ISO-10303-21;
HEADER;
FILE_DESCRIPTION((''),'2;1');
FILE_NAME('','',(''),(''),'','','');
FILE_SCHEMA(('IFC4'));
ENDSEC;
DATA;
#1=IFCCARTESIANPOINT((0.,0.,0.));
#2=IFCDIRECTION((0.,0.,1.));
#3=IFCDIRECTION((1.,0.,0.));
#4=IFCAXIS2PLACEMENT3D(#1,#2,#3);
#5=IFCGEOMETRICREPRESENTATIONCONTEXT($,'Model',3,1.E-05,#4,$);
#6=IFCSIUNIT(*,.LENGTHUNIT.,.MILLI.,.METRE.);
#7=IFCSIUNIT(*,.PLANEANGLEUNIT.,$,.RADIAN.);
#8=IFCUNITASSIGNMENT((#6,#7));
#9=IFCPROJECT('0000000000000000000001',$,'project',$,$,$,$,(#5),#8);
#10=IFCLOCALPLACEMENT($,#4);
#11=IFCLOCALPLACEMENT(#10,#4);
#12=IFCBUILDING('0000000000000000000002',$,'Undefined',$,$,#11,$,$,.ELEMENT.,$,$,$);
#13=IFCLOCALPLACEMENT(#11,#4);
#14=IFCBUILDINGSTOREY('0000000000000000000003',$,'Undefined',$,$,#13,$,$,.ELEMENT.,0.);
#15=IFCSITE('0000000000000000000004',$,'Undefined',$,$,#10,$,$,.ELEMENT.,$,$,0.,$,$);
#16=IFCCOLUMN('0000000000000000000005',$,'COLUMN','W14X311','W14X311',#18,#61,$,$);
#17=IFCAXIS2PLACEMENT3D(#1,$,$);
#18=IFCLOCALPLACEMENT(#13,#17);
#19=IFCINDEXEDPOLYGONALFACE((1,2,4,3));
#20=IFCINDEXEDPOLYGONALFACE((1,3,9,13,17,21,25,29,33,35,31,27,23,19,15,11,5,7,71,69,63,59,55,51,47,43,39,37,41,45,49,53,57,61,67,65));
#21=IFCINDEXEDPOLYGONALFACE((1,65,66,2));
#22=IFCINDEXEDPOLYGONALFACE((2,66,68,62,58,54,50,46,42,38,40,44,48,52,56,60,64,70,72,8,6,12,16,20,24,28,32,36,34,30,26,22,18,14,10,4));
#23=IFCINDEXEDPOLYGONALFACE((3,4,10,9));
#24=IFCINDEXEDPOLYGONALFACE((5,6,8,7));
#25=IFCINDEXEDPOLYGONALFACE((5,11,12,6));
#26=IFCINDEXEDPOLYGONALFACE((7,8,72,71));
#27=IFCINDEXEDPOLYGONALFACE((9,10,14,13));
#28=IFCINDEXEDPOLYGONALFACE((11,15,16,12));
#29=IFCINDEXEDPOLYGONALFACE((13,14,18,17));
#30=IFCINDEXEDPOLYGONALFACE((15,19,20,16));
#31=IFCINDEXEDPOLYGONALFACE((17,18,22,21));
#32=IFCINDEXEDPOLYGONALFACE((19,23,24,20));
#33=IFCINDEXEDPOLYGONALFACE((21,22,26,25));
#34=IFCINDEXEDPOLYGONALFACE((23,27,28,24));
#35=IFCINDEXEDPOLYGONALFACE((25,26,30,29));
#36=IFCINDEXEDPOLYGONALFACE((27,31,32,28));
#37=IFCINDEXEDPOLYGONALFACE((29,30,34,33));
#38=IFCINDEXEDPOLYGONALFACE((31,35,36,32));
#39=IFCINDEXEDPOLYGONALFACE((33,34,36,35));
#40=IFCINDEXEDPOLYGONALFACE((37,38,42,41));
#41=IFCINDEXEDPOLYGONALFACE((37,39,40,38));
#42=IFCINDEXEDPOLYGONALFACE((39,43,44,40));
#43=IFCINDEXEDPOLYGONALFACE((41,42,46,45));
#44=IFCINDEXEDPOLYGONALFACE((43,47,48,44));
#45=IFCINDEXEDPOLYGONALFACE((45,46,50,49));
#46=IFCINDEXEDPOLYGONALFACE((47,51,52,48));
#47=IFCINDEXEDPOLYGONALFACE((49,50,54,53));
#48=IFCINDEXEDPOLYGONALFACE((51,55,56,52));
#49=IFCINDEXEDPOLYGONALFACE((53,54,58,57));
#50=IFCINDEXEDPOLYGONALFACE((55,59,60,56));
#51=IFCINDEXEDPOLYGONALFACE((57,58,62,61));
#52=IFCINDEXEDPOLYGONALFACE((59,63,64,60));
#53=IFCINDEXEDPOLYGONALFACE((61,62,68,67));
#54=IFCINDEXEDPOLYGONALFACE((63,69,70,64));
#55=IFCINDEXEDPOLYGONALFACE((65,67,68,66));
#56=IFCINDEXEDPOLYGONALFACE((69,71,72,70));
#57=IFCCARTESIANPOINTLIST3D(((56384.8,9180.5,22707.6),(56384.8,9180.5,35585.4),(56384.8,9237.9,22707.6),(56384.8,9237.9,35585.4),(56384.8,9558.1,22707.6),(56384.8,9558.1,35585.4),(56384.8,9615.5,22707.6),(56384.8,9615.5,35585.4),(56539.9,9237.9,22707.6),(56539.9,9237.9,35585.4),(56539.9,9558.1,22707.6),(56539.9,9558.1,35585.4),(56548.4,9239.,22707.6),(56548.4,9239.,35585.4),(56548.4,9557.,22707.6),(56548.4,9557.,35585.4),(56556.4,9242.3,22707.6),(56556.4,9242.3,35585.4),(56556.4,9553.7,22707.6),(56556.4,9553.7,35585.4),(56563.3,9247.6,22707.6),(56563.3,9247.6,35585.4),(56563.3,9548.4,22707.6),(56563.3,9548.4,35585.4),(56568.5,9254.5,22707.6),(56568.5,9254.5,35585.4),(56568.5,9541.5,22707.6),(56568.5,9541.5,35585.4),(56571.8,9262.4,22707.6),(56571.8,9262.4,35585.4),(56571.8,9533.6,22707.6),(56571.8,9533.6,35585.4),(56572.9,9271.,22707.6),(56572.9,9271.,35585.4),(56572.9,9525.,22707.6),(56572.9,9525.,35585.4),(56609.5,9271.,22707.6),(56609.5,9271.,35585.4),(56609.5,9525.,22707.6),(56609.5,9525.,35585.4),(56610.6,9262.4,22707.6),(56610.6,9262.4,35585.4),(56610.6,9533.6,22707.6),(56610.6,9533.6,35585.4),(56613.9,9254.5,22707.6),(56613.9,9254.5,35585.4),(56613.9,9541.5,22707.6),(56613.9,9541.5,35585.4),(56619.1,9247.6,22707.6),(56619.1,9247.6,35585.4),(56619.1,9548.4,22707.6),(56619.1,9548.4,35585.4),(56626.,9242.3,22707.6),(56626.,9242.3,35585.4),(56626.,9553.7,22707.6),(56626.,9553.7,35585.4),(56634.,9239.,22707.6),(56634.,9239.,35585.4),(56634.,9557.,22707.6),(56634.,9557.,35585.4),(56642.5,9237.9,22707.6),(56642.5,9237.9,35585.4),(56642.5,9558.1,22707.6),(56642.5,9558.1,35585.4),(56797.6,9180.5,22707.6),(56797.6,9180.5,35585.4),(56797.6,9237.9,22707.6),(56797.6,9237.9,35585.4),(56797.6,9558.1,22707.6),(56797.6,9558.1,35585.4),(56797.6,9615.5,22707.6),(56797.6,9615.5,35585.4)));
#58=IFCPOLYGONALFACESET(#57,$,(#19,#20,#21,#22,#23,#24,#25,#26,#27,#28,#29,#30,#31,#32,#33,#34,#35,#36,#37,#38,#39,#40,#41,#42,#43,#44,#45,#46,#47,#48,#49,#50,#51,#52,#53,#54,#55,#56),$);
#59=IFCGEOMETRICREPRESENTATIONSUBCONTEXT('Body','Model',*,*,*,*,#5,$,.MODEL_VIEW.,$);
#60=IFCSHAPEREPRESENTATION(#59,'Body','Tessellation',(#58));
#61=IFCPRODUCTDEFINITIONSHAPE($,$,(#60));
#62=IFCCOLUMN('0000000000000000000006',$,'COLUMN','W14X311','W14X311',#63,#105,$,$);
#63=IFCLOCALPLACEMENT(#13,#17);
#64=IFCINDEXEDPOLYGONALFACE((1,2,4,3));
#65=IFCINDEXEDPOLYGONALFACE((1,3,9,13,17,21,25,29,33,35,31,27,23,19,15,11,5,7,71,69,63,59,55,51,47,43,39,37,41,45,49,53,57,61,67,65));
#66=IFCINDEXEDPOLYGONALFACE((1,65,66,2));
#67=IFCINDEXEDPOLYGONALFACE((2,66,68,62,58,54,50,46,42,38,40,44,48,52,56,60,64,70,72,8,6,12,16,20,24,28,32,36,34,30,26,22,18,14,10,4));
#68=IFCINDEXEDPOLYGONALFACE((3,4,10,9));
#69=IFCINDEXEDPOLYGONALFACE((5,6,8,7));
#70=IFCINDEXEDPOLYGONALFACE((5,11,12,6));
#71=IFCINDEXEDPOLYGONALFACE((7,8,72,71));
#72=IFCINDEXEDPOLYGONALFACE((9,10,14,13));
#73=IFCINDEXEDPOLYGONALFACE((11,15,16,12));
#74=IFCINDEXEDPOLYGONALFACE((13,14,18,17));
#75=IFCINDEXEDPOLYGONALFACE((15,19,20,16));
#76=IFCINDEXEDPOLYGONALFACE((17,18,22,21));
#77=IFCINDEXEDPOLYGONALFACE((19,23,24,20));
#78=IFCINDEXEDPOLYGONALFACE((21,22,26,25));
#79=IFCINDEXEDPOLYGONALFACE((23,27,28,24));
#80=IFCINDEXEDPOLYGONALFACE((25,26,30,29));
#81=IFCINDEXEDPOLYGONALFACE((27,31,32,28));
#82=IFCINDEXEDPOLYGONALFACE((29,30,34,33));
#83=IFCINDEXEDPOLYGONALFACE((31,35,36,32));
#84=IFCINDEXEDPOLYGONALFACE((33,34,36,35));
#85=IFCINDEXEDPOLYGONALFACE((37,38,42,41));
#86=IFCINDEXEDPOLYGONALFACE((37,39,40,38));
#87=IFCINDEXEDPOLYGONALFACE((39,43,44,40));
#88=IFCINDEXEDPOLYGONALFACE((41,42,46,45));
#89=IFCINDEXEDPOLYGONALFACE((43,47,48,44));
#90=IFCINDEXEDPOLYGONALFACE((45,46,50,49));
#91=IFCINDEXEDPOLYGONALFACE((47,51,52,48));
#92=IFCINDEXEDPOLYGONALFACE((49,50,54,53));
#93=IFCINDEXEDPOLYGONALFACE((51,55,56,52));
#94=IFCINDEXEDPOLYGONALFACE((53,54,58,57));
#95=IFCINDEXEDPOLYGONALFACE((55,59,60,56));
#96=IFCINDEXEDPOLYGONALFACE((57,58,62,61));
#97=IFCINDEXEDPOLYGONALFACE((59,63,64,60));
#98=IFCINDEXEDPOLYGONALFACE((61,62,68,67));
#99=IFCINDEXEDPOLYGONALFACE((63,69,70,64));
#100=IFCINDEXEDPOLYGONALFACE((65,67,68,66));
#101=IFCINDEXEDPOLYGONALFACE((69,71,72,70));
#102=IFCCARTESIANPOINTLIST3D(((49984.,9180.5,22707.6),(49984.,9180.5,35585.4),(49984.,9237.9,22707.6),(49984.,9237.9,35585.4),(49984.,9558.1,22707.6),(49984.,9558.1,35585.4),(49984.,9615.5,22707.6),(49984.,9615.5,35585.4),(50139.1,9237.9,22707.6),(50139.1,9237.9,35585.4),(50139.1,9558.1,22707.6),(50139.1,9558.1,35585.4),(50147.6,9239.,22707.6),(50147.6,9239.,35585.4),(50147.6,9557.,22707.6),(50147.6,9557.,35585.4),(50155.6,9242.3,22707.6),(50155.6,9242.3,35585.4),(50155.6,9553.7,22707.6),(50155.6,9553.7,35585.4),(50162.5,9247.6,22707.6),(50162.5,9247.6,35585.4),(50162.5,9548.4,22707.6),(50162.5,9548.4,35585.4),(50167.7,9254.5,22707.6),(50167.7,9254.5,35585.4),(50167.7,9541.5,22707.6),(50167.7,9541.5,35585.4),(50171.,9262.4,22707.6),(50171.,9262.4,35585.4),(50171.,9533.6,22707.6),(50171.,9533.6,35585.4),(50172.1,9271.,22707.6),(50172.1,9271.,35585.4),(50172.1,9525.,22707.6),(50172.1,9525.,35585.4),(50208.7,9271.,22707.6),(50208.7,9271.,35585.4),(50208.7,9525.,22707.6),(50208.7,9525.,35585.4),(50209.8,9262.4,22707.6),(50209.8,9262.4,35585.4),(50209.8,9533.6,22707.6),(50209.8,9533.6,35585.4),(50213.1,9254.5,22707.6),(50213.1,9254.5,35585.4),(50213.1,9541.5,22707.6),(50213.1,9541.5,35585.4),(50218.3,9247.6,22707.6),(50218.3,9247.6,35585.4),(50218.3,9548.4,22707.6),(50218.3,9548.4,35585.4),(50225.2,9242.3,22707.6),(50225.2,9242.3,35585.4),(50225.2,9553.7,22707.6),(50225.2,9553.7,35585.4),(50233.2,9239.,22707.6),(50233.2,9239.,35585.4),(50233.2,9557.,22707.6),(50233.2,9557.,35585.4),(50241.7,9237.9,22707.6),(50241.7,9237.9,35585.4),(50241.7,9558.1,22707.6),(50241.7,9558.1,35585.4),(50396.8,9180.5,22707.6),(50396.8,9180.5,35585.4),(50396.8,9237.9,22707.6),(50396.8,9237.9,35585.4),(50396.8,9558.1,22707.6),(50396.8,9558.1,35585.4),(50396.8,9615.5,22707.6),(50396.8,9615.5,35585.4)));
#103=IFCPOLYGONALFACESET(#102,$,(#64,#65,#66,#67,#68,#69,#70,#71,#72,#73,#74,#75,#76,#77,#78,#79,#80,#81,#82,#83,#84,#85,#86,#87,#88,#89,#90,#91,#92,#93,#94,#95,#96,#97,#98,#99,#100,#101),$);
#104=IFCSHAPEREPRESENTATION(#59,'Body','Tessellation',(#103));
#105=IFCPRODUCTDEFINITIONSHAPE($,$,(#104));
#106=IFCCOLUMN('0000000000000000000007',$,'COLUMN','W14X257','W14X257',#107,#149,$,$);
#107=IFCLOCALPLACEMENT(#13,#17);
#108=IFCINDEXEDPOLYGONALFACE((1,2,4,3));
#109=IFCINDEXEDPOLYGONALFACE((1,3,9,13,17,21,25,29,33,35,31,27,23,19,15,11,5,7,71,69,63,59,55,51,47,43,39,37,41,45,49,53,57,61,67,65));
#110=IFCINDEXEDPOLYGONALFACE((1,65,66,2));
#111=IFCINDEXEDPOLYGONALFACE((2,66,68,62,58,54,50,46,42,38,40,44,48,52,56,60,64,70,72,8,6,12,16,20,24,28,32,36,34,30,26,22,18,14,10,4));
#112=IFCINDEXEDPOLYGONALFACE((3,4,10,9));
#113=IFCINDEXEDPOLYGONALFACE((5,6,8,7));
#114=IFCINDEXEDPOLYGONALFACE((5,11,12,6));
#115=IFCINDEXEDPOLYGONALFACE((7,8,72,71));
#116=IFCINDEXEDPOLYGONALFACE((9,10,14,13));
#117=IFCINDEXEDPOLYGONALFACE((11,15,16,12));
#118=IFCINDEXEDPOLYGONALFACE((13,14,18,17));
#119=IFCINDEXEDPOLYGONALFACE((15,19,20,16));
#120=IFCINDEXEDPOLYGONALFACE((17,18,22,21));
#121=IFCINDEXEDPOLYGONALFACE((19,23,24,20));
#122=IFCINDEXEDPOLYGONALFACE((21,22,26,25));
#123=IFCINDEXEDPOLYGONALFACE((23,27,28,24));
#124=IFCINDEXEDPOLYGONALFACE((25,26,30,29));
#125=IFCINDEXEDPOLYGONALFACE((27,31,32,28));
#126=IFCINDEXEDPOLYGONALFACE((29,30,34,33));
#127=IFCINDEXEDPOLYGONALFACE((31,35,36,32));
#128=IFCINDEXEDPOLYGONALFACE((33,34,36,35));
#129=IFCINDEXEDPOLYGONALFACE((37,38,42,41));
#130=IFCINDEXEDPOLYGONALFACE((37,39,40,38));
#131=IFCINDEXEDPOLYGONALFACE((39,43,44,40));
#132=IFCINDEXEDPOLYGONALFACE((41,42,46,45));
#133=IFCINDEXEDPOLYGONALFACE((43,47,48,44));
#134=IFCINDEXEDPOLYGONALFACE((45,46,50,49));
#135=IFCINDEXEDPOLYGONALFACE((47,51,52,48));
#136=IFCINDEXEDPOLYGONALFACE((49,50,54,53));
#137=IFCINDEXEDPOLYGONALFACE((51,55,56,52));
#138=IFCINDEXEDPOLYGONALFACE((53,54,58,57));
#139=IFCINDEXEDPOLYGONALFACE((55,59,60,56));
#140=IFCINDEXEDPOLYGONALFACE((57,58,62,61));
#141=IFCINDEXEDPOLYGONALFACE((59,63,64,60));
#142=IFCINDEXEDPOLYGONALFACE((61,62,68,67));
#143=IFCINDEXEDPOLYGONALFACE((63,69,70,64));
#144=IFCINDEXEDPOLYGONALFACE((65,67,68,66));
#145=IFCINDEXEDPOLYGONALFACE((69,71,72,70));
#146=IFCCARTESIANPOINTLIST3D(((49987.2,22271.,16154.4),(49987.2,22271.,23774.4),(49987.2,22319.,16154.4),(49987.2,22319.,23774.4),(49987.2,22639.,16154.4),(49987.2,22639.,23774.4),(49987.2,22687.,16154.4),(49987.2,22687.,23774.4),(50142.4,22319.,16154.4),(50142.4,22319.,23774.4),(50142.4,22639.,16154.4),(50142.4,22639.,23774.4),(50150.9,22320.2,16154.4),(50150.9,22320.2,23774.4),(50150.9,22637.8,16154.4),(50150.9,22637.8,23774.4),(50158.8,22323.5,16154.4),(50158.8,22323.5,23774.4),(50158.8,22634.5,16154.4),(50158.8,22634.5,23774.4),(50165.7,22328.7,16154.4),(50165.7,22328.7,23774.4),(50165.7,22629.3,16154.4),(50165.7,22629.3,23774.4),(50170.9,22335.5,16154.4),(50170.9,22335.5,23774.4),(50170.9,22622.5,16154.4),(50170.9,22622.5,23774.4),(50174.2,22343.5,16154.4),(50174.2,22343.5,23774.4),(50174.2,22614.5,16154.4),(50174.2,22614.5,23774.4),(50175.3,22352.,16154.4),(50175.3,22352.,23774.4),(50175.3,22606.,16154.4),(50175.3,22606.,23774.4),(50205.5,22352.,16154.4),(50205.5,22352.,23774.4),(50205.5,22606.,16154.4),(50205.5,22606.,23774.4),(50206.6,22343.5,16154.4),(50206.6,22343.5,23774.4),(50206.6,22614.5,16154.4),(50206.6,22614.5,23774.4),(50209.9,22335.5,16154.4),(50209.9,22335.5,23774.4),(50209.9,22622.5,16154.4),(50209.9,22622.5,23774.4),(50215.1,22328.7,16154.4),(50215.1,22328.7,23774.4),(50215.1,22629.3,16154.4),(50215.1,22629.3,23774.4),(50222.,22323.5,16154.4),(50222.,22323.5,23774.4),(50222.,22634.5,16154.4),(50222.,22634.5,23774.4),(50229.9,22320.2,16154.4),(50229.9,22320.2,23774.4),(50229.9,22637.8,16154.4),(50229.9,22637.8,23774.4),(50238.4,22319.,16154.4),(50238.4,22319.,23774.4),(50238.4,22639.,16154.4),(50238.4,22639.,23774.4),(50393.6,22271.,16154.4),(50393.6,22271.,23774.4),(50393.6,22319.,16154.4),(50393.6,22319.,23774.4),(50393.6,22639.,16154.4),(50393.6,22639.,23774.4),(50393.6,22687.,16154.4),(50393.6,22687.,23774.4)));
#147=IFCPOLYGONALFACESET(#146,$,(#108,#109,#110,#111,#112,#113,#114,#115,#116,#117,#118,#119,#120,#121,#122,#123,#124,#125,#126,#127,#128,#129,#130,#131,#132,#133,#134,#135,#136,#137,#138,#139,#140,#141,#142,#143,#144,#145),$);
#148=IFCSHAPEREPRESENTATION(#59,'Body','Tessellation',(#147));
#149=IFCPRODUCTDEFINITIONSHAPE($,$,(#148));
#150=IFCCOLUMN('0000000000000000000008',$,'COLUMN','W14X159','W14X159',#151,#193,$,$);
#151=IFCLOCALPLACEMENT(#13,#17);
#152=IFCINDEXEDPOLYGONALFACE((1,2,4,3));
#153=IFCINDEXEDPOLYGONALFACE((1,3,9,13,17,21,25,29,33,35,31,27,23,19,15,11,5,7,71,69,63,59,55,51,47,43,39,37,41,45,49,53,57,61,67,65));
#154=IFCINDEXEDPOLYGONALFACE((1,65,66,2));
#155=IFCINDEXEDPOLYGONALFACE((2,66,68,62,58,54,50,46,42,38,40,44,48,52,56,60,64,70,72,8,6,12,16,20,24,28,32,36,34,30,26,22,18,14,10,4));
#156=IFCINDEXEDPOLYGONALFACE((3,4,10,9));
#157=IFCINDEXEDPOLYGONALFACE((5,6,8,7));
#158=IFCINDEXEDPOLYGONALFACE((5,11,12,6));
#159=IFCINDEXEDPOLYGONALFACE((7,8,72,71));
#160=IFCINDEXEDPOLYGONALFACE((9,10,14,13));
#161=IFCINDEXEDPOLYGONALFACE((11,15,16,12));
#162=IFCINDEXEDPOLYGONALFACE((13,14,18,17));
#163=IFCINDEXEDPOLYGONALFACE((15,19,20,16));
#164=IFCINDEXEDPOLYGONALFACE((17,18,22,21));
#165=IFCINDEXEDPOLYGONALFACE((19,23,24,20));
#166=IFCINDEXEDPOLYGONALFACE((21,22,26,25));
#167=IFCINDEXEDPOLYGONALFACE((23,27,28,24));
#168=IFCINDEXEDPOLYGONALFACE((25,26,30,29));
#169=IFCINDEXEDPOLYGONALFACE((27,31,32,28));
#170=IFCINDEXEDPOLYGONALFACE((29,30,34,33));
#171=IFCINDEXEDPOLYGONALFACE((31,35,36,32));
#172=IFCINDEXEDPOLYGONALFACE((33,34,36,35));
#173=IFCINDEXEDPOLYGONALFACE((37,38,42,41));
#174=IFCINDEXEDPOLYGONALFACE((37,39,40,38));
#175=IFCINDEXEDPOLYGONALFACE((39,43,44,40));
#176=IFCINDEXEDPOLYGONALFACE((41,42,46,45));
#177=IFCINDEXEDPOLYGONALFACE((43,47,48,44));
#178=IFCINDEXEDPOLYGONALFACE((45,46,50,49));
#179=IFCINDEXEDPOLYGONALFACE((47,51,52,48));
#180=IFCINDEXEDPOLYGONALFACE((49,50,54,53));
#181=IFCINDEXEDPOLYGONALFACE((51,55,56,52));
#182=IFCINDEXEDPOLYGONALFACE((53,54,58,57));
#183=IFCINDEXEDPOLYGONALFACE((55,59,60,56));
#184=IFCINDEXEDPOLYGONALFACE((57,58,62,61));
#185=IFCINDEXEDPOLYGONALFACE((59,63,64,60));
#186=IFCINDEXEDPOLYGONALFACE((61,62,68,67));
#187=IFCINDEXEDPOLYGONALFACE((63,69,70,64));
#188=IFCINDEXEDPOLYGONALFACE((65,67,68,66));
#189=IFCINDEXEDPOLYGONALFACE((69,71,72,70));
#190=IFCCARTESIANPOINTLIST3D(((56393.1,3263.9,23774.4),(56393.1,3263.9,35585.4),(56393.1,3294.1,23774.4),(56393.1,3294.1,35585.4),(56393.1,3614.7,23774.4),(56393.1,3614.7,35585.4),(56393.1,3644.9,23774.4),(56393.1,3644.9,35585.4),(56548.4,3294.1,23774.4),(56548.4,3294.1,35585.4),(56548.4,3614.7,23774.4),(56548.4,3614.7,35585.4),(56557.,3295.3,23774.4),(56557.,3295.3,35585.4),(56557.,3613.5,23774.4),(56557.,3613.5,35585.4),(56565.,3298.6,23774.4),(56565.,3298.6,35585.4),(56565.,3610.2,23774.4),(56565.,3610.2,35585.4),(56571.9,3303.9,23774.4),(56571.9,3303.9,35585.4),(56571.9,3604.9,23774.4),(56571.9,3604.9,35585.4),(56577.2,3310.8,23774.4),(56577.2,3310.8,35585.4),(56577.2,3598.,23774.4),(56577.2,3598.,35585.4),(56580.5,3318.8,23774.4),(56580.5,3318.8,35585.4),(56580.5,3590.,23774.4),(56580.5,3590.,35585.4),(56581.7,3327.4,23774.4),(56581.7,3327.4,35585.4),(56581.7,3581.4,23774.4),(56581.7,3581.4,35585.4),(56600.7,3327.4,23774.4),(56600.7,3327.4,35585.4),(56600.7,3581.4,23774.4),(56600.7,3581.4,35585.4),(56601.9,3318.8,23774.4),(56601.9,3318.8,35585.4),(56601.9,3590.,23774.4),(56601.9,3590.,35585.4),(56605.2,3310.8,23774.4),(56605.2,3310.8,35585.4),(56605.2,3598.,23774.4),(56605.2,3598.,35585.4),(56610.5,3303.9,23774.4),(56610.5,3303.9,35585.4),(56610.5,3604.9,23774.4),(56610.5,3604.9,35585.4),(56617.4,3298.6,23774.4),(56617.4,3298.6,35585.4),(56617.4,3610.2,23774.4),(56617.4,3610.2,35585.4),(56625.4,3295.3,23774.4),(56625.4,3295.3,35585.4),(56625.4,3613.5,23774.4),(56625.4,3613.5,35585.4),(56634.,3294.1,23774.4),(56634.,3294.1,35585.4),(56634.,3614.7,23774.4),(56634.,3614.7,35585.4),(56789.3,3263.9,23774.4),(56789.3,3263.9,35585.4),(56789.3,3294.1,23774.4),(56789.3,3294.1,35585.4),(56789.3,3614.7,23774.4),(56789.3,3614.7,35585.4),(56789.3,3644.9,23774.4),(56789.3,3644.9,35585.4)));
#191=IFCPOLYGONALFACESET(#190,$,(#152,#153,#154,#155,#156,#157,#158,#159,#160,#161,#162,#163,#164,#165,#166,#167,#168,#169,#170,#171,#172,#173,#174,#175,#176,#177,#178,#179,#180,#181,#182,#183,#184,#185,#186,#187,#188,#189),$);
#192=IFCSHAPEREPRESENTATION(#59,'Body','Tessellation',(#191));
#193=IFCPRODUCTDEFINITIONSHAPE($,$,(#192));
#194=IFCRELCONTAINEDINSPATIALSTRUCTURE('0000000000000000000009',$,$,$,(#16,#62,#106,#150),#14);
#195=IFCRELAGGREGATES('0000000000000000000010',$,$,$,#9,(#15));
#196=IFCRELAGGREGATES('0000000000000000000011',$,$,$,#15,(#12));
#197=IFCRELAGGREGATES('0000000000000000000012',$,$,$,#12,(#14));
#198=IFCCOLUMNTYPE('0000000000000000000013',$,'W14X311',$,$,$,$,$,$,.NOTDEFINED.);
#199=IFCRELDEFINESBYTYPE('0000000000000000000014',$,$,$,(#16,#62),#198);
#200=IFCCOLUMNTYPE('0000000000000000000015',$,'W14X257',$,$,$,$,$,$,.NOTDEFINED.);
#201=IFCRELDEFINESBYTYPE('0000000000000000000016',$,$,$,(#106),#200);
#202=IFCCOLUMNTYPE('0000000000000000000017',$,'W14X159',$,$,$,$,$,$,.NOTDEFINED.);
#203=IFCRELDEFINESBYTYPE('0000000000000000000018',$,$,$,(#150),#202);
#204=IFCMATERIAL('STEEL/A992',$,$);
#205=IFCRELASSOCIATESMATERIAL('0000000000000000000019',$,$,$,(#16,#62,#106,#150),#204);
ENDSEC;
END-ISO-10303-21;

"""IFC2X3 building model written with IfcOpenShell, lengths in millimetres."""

from ifc_helpers import new_model, si_unit, frame, origin_with_axes, origin_2d_with_axis, place, context, subcontext, project, spatial, i_section, extrude, material, type_object, element, save


model = new_model("IFC2X3")

# Units and contexts
model_context = context("Model", 3, precision=1e-05, world=origin_with_axes())
body_context = subcontext(model_context, "Body", "Model", "MODEL_VIEW")
ifc_project = project(units=[si_unit("LENGTHUNIT", "METRE", prefix="MILLI"), si_unit("PLANEANGLEUNIT", "RADIAN")], contexts=[model_context])

# Site, building, storey
site_placement = place(None, origin_with_axes())
site = spatial("IfcSite", under=ifc_project, at=site_placement, Name="Undefined", CompositionType="ELEMENT", RefElevation=0.0)
building_placement = place(site_placement, origin_with_axes())
building = spatial("IfcBuilding", under=site, at=building_placement, Name="Undefined", CompositionType="ELEMENT")
storey_placement = place(building_placement, origin_with_axes())
storey = spatial("IfcBuildingStorey", under=building, at=storey_placement, Name="Undefined", CompositionType="ELEMENT", Elevation=0.0)

# Columns
ifc_material_1 = material(Name="STEEL/A992")
column_type_1 = type_object("IfcColumnType", Name="W14X311", PredefinedType="NOTDEFINED")
for number, where, z_axis, x_axis, name in (
    (1, (56591.2, 9398.0, 22707.6), (0.0, 0.0, 1.0), (1.0, 0.0, 0.0), "COLUMN"),
    (2, (50190.4, 9398.0, 22707.6), (0.0, 0.0, 1.0), (1.0, 0.0, 0.0), "COLUMN"),
):
    element("IfcColumn", number, at=place(storey_placement, frame(where, z_axis=z_axis, x_axis=x_axis)), inside=storey, type_object=column_type_1, material=ifc_material_1, Name=name, Description="W14X311", ObjectType="W14X311", context=body_context, shape_type="SweptSolid", body=[
        extrude(i_section(OverallWidth=412.8, OverallDepth=435.0, WebThickness=36.5, FlangeThickness=57.4, FilletRadius=33.1, at=origin_2d_with_axis()), frame((0.0, 0.0, 12877.8), z_axis=(0.0, 0.0, -1.0), x_axis=(-1.0, 0.0, 0.0)), (0.0, 0.0, 1.0), 12877.8),
    ])
column_type_2 = type_object("IfcColumnType", Name="W14X257", PredefinedType="NOTDEFINED")
column_1_placement = place(storey_placement, frame((50190.4, 22479.0, 16154.4), z_axis=(0.0, 0.0, 1.0), x_axis=(1.0, 0.0, 0.0)))
element("IfcColumn", 3, at=column_1_placement, inside=storey, type_object=column_type_2, material=ifc_material_1, Name="COLUMN", Description="W14X257", ObjectType="W14X257", context=body_context, shape_type="SweptSolid", body=[
    extrude(i_section(OverallWidth=406.4, OverallDepth=415.9, WebThickness=30.2, FlangeThickness=48.0, FilletRadius=33.0, at=origin_2d_with_axis()), frame((0.0, 0.0, 7620.0), z_axis=(0.0, 0.0, -1.0), x_axis=(-1.0, 0.0, 0.0)), (0.0, 0.0, 1.0), 7620.0),
])
column_type_3 = type_object("IfcColumnType", Name="W14X159", PredefinedType="NOTDEFINED")
column_2_placement = place(storey_placement, frame((56591.2, 3454.4, 23774.4), z_axis=(0.0, 0.0, 1.0), x_axis=(1.0, 0.0, 0.0)))
element("IfcColumn", 4, at=column_2_placement, inside=storey, type_object=column_type_3, material=ifc_material_1, Name="COLUMN", Description="W14X159", ObjectType="W14X159", context=body_context, shape_type="SweptSolid", body=[
    extrude(i_section(OverallWidth=396.2, OverallDepth=381.0, WebThickness=19.0, FlangeThickness=30.2, FilletRadius=33.3, at=origin_2d_with_axis()), frame((0.0, 0.0, 11811.0), z_axis=(0.0, 0.0, -1.0), x_axis=(-1.0, 0.0, 0.0)), (0.0, 0.0, 1.0), 11811.0),
])

save(model, "model.ifc")
